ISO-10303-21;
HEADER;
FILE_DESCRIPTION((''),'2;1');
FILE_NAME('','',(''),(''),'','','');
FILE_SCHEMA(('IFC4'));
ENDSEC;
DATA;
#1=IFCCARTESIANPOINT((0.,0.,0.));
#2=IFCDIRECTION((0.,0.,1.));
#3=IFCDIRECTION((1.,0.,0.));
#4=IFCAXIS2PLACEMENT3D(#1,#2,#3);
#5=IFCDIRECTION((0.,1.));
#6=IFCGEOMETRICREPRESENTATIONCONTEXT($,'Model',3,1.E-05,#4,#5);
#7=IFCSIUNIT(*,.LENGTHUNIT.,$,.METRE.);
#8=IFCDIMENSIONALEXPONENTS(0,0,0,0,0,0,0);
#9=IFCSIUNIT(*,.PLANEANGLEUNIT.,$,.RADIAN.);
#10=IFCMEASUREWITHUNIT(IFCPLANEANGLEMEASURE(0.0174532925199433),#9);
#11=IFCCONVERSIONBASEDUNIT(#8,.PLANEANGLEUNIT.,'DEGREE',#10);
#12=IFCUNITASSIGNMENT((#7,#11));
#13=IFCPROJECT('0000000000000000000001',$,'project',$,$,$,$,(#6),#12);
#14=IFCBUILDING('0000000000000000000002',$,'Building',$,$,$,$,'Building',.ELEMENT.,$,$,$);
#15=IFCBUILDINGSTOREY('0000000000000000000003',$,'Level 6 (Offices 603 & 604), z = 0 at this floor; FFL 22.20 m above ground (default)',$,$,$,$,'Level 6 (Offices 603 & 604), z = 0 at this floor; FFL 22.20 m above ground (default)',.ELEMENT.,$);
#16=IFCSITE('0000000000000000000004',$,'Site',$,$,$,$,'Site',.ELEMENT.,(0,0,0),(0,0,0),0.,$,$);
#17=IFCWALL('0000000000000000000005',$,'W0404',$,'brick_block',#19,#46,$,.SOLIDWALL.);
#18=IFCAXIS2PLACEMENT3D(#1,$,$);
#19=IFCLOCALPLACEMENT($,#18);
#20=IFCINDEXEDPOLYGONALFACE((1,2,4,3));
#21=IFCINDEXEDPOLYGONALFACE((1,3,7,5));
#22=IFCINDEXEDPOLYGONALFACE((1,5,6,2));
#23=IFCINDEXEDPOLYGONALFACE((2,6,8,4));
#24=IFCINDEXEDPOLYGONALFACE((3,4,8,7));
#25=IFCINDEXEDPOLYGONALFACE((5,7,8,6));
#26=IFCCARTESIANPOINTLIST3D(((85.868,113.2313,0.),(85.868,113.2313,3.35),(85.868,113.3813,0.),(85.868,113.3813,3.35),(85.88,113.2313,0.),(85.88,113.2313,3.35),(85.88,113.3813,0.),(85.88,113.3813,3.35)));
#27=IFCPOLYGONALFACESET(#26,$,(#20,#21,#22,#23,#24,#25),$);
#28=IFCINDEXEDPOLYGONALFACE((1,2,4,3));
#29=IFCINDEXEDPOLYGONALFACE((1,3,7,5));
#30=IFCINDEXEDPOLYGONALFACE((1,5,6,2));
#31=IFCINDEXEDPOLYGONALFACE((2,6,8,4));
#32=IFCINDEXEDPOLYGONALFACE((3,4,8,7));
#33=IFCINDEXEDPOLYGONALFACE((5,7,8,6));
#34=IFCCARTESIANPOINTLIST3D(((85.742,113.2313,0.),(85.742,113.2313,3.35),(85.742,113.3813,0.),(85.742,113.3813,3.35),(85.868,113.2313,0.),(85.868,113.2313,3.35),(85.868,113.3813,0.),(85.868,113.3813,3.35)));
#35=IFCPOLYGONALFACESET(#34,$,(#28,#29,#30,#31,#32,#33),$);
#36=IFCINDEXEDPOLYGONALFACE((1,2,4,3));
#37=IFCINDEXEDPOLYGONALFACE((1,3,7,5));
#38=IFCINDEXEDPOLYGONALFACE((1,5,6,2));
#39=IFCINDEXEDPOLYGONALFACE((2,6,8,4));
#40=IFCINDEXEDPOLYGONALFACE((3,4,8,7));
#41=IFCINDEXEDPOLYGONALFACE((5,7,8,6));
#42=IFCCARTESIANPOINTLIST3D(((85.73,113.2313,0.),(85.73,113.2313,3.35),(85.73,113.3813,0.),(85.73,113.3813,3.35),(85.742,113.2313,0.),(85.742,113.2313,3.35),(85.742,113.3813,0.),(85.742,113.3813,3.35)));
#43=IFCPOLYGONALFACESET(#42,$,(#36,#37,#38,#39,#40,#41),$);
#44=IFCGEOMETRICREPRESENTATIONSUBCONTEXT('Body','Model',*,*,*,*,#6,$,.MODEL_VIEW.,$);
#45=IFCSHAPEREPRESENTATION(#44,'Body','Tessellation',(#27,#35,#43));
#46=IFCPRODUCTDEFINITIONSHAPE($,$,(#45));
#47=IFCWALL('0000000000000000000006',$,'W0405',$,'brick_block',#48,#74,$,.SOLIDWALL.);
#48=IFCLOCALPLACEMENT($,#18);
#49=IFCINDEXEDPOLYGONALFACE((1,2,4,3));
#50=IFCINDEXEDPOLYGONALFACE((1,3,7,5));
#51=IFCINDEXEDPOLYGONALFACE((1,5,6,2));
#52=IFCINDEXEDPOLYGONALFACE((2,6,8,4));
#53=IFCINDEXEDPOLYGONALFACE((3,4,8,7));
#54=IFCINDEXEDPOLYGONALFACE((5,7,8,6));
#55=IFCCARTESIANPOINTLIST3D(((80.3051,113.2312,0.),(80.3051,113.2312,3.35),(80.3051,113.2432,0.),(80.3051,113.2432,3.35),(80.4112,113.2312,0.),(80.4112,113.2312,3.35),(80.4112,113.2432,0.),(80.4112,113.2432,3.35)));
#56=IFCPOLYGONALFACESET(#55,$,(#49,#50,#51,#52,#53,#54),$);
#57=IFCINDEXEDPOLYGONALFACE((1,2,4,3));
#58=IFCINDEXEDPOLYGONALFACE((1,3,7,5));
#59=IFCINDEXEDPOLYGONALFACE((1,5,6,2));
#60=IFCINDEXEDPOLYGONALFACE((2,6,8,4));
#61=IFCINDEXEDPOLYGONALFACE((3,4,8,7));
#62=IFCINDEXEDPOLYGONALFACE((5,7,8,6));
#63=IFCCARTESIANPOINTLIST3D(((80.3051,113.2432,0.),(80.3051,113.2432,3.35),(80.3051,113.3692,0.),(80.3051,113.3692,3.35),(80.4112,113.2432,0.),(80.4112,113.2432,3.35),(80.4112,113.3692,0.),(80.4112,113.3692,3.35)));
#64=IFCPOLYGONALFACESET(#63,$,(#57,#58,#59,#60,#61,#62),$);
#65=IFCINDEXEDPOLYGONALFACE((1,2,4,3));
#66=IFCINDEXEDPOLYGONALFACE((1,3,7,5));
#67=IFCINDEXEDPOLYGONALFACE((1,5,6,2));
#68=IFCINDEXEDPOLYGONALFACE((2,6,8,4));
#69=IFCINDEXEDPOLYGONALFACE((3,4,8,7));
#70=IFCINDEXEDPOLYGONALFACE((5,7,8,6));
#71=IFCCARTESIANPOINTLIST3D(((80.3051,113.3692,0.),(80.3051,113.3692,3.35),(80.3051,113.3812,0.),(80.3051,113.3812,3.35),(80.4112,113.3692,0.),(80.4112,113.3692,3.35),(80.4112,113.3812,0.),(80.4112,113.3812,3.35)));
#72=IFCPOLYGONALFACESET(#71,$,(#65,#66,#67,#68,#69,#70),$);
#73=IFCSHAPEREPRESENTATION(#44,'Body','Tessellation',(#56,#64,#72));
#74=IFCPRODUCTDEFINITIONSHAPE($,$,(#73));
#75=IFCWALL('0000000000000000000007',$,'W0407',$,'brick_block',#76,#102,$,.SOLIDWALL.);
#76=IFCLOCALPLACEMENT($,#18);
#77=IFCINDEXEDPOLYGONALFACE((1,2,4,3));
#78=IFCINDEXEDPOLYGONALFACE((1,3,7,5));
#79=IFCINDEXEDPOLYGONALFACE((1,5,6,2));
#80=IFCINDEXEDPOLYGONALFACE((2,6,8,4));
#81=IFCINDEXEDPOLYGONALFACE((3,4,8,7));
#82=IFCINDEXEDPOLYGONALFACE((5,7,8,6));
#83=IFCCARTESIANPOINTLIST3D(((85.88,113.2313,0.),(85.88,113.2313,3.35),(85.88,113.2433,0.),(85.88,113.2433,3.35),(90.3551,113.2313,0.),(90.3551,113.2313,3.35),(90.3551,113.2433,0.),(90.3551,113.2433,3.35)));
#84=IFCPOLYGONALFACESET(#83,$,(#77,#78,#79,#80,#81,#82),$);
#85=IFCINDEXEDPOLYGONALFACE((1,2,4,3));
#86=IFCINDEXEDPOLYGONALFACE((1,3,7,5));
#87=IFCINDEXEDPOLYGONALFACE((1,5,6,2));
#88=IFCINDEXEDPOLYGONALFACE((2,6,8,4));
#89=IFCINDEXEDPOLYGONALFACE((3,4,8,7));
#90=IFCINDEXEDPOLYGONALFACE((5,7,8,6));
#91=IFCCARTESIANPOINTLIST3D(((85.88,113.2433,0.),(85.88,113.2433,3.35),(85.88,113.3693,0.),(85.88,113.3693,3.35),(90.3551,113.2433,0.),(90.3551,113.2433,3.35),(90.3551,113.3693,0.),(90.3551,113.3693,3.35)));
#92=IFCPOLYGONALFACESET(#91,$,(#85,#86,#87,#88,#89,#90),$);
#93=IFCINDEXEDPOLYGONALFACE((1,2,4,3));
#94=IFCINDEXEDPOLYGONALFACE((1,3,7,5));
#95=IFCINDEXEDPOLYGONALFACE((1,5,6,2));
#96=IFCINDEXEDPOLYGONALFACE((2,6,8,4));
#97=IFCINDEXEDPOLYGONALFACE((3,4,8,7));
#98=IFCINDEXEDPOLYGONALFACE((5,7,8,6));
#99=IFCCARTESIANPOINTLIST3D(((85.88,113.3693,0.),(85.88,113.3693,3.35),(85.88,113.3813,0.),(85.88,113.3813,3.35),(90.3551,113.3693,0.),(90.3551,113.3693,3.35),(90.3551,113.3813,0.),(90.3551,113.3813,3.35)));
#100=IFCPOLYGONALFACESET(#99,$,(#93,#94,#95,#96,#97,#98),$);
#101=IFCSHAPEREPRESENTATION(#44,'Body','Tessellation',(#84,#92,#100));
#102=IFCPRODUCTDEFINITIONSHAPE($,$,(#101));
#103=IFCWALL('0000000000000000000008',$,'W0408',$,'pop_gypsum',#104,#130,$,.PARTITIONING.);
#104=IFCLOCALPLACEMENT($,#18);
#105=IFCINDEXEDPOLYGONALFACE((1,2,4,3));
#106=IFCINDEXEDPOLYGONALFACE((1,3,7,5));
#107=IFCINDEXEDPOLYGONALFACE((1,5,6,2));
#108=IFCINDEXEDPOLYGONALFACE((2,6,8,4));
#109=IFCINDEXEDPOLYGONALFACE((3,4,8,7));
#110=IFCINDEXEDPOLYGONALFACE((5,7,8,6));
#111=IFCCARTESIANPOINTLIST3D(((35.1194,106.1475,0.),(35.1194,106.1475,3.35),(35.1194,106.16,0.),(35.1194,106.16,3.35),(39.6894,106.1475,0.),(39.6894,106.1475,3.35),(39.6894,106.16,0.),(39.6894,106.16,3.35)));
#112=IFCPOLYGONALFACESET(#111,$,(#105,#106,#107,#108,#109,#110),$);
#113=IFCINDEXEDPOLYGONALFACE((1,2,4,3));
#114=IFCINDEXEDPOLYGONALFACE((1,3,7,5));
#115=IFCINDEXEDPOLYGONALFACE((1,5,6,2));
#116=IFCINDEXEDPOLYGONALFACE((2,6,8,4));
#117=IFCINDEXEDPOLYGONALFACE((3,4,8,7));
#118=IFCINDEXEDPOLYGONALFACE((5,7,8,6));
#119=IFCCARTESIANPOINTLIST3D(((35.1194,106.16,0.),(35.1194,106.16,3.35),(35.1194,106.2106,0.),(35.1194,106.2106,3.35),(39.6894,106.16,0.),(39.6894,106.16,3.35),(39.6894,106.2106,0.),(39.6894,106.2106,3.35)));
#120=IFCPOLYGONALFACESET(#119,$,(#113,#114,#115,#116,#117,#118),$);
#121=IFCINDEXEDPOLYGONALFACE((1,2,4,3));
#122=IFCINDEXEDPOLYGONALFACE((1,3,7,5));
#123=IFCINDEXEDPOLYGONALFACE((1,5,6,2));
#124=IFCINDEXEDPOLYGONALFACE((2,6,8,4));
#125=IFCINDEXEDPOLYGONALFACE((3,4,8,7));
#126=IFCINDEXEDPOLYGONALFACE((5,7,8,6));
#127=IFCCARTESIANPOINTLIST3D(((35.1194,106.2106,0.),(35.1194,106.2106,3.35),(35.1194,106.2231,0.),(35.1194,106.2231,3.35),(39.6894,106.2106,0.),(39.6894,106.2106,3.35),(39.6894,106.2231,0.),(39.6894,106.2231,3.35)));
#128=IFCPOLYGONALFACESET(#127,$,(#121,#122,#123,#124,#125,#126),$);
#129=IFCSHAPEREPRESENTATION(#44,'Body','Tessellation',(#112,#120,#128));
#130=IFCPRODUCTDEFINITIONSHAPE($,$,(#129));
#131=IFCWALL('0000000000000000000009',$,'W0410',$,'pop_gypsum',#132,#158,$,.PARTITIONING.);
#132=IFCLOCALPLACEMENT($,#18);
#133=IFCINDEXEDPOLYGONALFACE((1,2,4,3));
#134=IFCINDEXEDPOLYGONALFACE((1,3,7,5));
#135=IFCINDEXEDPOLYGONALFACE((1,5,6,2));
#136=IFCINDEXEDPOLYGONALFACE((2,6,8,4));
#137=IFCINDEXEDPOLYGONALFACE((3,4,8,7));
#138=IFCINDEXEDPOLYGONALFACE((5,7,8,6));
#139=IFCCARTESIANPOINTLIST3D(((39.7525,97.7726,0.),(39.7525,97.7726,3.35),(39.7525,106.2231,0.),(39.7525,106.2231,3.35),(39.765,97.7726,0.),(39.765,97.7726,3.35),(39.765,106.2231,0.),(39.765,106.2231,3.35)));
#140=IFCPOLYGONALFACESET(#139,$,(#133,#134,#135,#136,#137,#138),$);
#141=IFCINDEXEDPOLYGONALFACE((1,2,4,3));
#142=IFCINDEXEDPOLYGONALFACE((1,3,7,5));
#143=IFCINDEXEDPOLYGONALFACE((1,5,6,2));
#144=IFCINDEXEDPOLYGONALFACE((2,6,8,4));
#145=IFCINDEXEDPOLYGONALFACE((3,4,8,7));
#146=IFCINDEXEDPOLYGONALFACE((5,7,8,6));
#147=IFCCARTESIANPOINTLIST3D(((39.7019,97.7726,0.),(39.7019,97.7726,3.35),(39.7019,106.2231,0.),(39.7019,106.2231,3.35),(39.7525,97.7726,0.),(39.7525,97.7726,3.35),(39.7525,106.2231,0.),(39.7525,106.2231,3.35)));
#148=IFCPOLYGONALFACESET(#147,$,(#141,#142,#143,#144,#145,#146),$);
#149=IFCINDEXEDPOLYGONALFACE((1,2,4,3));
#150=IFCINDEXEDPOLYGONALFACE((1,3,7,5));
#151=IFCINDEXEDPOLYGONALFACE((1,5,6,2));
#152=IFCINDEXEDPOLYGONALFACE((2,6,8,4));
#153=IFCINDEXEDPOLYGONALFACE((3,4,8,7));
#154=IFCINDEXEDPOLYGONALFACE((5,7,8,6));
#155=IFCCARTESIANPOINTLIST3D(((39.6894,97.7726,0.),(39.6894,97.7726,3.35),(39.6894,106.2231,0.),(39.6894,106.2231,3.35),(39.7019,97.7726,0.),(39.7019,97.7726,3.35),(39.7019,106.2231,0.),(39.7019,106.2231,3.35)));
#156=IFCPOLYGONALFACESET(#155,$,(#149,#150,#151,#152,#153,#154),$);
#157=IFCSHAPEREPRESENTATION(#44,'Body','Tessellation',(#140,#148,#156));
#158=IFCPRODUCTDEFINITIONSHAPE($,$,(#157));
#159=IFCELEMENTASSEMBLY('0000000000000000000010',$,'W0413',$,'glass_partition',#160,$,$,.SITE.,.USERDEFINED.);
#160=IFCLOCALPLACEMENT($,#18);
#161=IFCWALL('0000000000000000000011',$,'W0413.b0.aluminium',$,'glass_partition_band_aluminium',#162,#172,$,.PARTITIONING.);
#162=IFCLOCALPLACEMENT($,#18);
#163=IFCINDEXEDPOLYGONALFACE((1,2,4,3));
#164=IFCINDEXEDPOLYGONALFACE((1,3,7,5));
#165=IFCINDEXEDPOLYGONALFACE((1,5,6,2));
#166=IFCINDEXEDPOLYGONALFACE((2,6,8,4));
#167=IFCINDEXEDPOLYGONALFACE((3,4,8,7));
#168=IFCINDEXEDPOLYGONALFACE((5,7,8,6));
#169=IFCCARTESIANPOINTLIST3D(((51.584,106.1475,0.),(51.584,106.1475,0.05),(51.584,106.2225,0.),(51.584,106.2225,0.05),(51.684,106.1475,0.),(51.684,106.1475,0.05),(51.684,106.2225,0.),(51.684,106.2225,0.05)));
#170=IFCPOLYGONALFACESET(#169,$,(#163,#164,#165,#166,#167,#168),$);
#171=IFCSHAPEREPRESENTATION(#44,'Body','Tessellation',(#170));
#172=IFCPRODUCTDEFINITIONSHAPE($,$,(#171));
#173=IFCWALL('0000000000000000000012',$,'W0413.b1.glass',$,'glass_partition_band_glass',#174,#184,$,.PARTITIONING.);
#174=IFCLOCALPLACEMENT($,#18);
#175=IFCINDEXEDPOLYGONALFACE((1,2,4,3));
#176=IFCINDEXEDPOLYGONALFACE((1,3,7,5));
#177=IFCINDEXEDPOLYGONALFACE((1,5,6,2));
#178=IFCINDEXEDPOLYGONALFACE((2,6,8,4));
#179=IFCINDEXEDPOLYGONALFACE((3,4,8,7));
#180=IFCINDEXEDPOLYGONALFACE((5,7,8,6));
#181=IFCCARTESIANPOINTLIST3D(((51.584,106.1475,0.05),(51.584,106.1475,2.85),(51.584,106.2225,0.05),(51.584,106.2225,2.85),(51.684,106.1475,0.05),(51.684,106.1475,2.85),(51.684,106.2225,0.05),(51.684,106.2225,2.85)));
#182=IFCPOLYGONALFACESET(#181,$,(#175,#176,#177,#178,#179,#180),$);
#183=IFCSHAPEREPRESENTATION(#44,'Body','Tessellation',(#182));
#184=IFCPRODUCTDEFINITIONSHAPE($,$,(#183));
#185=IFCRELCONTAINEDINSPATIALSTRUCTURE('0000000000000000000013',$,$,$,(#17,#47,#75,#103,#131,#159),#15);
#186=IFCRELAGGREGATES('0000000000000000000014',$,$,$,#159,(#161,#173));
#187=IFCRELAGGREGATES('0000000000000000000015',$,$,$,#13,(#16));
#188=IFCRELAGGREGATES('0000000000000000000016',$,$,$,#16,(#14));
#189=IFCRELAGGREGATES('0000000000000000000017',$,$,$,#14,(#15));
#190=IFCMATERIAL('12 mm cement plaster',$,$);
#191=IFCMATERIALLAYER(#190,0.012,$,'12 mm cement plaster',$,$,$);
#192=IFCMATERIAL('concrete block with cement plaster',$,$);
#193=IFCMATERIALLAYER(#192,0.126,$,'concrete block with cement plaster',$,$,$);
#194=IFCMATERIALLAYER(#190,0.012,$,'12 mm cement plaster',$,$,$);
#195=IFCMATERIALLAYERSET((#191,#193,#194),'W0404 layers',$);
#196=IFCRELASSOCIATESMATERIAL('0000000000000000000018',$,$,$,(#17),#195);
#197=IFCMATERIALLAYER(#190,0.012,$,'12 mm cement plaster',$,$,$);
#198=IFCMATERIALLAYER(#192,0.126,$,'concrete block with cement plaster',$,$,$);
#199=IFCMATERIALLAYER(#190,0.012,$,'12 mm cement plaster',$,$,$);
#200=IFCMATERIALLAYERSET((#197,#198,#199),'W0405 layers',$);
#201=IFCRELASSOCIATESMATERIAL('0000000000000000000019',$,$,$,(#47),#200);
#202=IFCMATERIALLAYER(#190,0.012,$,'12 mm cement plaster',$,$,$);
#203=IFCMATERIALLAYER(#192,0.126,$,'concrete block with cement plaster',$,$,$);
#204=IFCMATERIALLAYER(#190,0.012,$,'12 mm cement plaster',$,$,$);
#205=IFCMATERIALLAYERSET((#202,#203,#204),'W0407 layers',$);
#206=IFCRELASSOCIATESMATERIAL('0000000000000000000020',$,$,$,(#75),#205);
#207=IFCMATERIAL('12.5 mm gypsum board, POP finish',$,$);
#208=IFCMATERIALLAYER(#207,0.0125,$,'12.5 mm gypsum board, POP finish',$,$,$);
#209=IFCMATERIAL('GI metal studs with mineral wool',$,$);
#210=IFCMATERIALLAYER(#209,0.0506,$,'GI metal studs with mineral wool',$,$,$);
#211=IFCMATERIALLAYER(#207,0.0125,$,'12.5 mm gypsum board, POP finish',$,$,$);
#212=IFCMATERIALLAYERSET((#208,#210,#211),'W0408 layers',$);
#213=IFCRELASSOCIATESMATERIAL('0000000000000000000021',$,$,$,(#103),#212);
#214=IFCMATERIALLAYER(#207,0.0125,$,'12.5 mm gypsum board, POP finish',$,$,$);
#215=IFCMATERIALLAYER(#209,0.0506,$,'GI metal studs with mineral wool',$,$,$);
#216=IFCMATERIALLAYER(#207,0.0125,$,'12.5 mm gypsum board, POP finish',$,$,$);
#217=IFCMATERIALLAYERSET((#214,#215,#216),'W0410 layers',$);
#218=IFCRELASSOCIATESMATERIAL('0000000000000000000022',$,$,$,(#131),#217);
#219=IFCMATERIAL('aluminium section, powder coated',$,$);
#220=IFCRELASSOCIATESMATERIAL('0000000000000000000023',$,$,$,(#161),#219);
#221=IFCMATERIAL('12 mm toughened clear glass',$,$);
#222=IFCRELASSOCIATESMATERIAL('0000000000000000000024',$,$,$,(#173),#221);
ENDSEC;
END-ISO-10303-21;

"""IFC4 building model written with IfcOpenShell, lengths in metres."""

from ifc_helpers import new_model, entity, si_unit, converted_unit, direction, frame, frame_2d, origin_with_axes, origin_2d_with_axis, place, context, subcontext, project, spatial, rectangle, extrude, material, layer, layer_set, layer_usage, element, aggregate, save


model = new_model("IFC4")

# Units and contexts
model_context = context("Model", 3, precision=1e-05, world=origin_with_axes(), true_north=direction((0.0, 1.0)))
body_context = subcontext(model_context, "Body", "Model", "MODEL_VIEW")
ifc_project = project(units=[si_unit("LENGTHUNIT", "METRE"), converted_unit("PLANEANGLEUNIT", "DEGREE", entity("IfcPlaneAngleMeasure", 0.0174532925199433), si_unit("PLANEANGLEUNIT", "RADIAN"), dimensions=[0, 0, 0, 0, 0, 0, 0])], contexts=[model_context])

# Site, building, storey
site = spatial("IfcSite", under=ifc_project, Name="Site", LongName="Site", CompositionType="ELEMENT", RefLatitude=(0, 0, 0), RefLongitude=(0, 0, 0), RefElevation=0.0)
building = spatial("IfcBuilding", under=site, Name="Building", LongName="Building", CompositionType="ELEMENT")
storey = spatial("IfcBuildingStorey", under=building, Name="Level 6 (Offices 603 & 604), z = 0 at this floor; FFL 22.20 m above ground (default)", LongName="Level 6 (Offices 603 & 604), z = 0 at this floor; FFL 22.20 m above ground (default)", CompositionType="ELEMENT")

# Shared definitions
placement = place(None, origin_with_axes())

# Shared definitions
ifc_material_1 = material(Name="12.5 mm gypsum board, POP finish")
ifc_material_2 = material(Name="GI metal studs with mineral wool")

# Shared definitions
ifc_material_3 = material(Name="aluminium section, powder coated")
ifc_material_4 = material(Name="12 mm toughened clear glass")

# Walls
ifc_material_5 = material(Name="12 mm cement plaster")
ifc_material_6 = material(Name="concrete block with cement plaster")
ifc_layer_1 = layer(ifc_material_5, 0.012, Name="12 mm cement plaster")
ifc_layer_2 = layer(ifc_material_6, 0.126, Name="concrete block with cement plaster")
ifc_layer_3 = layer(ifc_material_5, 0.012, Name="12 mm cement plaster")
ifc_layer_set_1 = layer_set([ifc_layer_1, ifc_layer_2, ifc_layer_3], Name="W0404 layers")
ifc_layer_usage_1 = layer_usage(ifc_layer_set_1, "AXIS2", "POSITIVE", -0.075)
element("IfcWall", 1, at=placement, inside=storey, material=ifc_layer_usage_1, Name="W0404", ObjectType="brick_block", PredefinedType="SOLIDWALL", context=body_context, shape_type="SweptSolid", body=[
    extrude(rectangle(XDim=0.15, YDim=0.012, at=frame_2d((0.0, 0.0), x_axis=(0.0, 1.0))), frame((85.874, 113.3063, 0.0), z_axis=(0.0, 0.0, 1.0), x_axis=(1.0, 0.0, 0.0)), (0.0, 0.0, 1.0), 3.35),
    extrude(rectangle(XDim=0.15, YDim=0.126, at=frame_2d((-0.069, 0.0), x_axis=(0.0, 1.0))), frame((85.874, 113.3063, 0.0), z_axis=(0.0, 0.0, 1.0), x_axis=(1.0, 0.0, 0.0)), (0.0, 0.0, 1.0), 3.35),
    extrude(rectangle(XDim=0.15, YDim=0.012, at=frame_2d((-0.138, 0.0), x_axis=(0.0, 1.0))), frame((85.874, 113.3063, 0.0), z_axis=(0.0, 0.0, 1.0), x_axis=(1.0, 0.0, 0.0)), (0.0, 0.0, 1.0), 3.35),
])
ifc_layer_4 = layer(ifc_material_5, 0.012, Name="12 mm cement plaster")
ifc_layer_5 = layer(ifc_material_6, 0.126, Name="concrete block with cement plaster")
ifc_layer_6 = layer(ifc_material_5, 0.012, Name="12 mm cement plaster")
ifc_layer_set_2 = layer_set([ifc_layer_4, ifc_layer_5, ifc_layer_6], Name="W0405 layers")
ifc_layer_usage_2 = layer_usage(ifc_layer_set_2, "AXIS2", "POSITIVE", -0.075)
element("IfcWall", 2, at=placement, inside=storey, material=ifc_layer_usage_2, Name="W0405", ObjectType="brick_block", PredefinedType="SOLIDWALL", context=body_context, shape_type="SweptSolid", body=[
    extrude(rectangle(XDim=0.1061, YDim=0.012, at=origin_2d_with_axis()), frame((80.3581, 113.2372, 0.0), z_axis=(0.0, 0.0, 1.0), x_axis=(1.0, 0.0, 0.0)), (0.0, 0.0, 1.0), 3.35),
    extrude(rectangle(XDim=0.1061, YDim=0.126, at=frame_2d((0.0, 0.069), x_axis=(1.0, 0.0))), frame((80.3581, 113.2372, 0.0), z_axis=(0.0, 0.0, 1.0), x_axis=(1.0, 0.0, 0.0)), (0.0, 0.0, 1.0), 3.35),
    extrude(rectangle(XDim=0.1061, YDim=0.012, at=frame_2d((0.0, 0.138), x_axis=(1.0, 0.0))), frame((80.3581, 113.2372, 0.0), z_axis=(0.0, 0.0, 1.0), x_axis=(1.0, 0.0, 0.0)), (0.0, 0.0, 1.0), 3.35),
])
ifc_layer_7 = layer(ifc_material_5, 0.012, Name="12 mm cement plaster")
ifc_layer_8 = layer(ifc_material_6, 0.126, Name="concrete block with cement plaster")
ifc_layer_9 = layer(ifc_material_5, 0.012, Name="12 mm cement plaster")
ifc_layer_set_3 = layer_set([ifc_layer_7, ifc_layer_8, ifc_layer_9], Name="W0407 layers")
ifc_layer_usage_3 = layer_usage(ifc_layer_set_3, "AXIS2", "POSITIVE", -0.075)
element("IfcWall", 3, at=placement, inside=storey, material=ifc_layer_usage_3, Name="W0407", ObjectType="brick_block", PredefinedType="SOLIDWALL", context=body_context, shape_type="SweptSolid", body=[
    extrude(rectangle(XDim=4.4751, YDim=0.012, at=frame_2d((0.0, 0.0), x_axis=(1.0, 0.0))), frame((88.1175, 113.2373, 0.0), z_axis=(0.0, 0.0, 1.0), x_axis=(1.0, 0.0, 0.0)), (0.0, 0.0, 1.0), 3.35),
    extrude(rectangle(XDim=4.4751, YDim=0.126, at=frame_2d((0.0, 0.069), x_axis=(1.0, 0.0))), frame((88.1175, 113.2373, 0.0), z_axis=(0.0, 0.0, 1.0), x_axis=(1.0, 0.0, 0.0)), (0.0, 0.0, 1.0), 3.35),
    extrude(rectangle(XDim=4.4751, YDim=0.012, at=frame_2d((0.0, 0.138), x_axis=(1.0, 0.0))), frame((88.1175, 113.2373, 0.0), z_axis=(0.0, 0.0, 1.0), x_axis=(1.0, 0.0, 0.0)), (0.0, 0.0, 1.0), 3.35),
])
ifc_layer_10 = layer(ifc_material_1, 0.0125, Name="12.5 mm gypsum board, POP finish")
ifc_layer_11 = layer(ifc_material_2, 0.0506, Name="GI metal studs with mineral wool")
ifc_layer_12 = layer(ifc_material_1, 0.0125, Name="12.5 mm gypsum board, POP finish")
ifc_layer_set_4 = layer_set([ifc_layer_10, ifc_layer_11, ifc_layer_12], Name="W0408 layers")
ifc_layer_usage_4 = layer_usage(ifc_layer_set_4, "AXIS2", "POSITIVE", -0.0378)
element("IfcWall", 4, at=placement, inside=storey, material=ifc_layer_usage_4, Name="W0408", ObjectType="pop_gypsum", PredefinedType="PARTITIONING", context=body_context, shape_type="SweptSolid", body=[
    extrude(rectangle(XDim=4.57, YDim=0.0125, at=frame_2d((0.0, 0.0), x_axis=(1.0, 0.0))), frame((37.4044, 106.1538, 0.0), z_axis=(0.0, 0.0, 1.0), x_axis=(1.0, 0.0, 0.0)), (0.0, 0.0, 1.0), 3.35),
    extrude(rectangle(XDim=4.57, YDim=0.0506, at=frame_2d((0.0, 0.0315), x_axis=(1.0, 0.0))), frame((37.4044, 106.1538, 0.0), z_axis=(0.0, 0.0, 1.0), x_axis=(1.0, 0.0, 0.0)), (0.0, 0.0, 1.0), 3.35),
    extrude(rectangle(XDim=4.57, YDim=0.0125, at=frame_2d((0.0, 0.0631), x_axis=(1.0, 0.0))), frame((37.4044, 106.1538, 0.0), z_axis=(0.0, 0.0, 1.0), x_axis=(1.0, 0.0, 0.0)), (0.0, 0.0, 1.0), 3.35),
])
ifc_layer_13 = layer(ifc_material_1, 0.0125, Name="12.5 mm gypsum board, POP finish")
ifc_layer_14 = layer(ifc_material_2, 0.0506, Name="GI metal studs with mineral wool")
ifc_layer_15 = layer(ifc_material_1, 0.0125, Name="12.5 mm gypsum board, POP finish")
ifc_layer_set_5 = layer_set([ifc_layer_13, ifc_layer_14, ifc_layer_15], Name="W0410 layers")
ifc_layer_usage_5 = layer_usage(ifc_layer_set_5, "AXIS2", "POSITIVE", -0.0378)
element("IfcWall", 5, at=placement, inside=storey, material=ifc_layer_usage_5, Name="W0410", ObjectType="pop_gypsum", PredefinedType="PARTITIONING", context=body_context, shape_type="SweptSolid", body=[
    extrude(rectangle(XDim=8.4505, YDim=0.0125, at=frame_2d((0.0, 0.0), x_axis=(0.0, 1.0))), frame((39.7587, 101.9978, 0.0), z_axis=(0.0, 0.0, 1.0), x_axis=(1.0, 0.0, 0.0)), (0.0, 0.0, 1.0), 3.35),
    extrude(rectangle(XDim=8.4505, YDim=0.0506, at=frame_2d((-0.0315, 0.0), x_axis=(0.0, 1.0))), frame((39.7587, 101.9978, 0.0), z_axis=(0.0, 0.0, 1.0), x_axis=(1.0, 0.0, 0.0)), (0.0, 0.0, 1.0), 3.35),
    extrude(rectangle(XDim=8.4505, YDim=0.0125, at=frame_2d((-0.0631, 0.0), x_axis=(0.0, 1.0))), frame((39.7587, 101.9978, 0.0), z_axis=(0.0, 0.0, 1.0), x_axis=(1.0, 0.0, 0.0)), (0.0, 0.0, 1.0), 3.35),
])

# Element assembly, walls
assembly_1 = element("IfcElementAssembly", 6, inside=storey, Name="W0413", ObjectType="glass_partition", AssemblyPlace="SITE", PredefinedType="USERDEFINED")
wall_1 = element("IfcWall", 7, at=placement, material=ifc_material_3, Name="W0413.b0.aluminium", ObjectType="glass_partition_band_aluminium", PredefinedType="PARTITIONING", context=body_context, shape_type="SweptSolid", body=[
    extrude(rectangle(XDim=0.1, YDim=0.075, at=frame_2d((0.0, 0.0), x_axis=(1.0, 0.0))), frame((51.634, 106.185, 0.0), z_axis=(0.0, 0.0, 1.0), x_axis=(1.0, 0.0, 0.0)), (0.0, 0.0, 1.0), 0.05),
])
wall_2 = element("IfcWall", 8, at=placement, material=ifc_material_4, Name="W0413.b1.glass", ObjectType="glass_partition_band_glass", PredefinedType="PARTITIONING", context=body_context, shape_type="SweptSolid", body=[
    extrude(rectangle(XDim=0.1, YDim=0.075, at=frame_2d((0.0, 0.0), x_axis=(1.0, 0.0))), frame((51.634, 106.185, 0.05), z_axis=(0.0, 0.0, 1.0), x_axis=(1.0, 0.0, 0.0)), (0.0, 0.0, 1.0), 2.8),
])
aggregate(assembly_1, [wall_1, wall_2])

save(model, "model.ifc")
